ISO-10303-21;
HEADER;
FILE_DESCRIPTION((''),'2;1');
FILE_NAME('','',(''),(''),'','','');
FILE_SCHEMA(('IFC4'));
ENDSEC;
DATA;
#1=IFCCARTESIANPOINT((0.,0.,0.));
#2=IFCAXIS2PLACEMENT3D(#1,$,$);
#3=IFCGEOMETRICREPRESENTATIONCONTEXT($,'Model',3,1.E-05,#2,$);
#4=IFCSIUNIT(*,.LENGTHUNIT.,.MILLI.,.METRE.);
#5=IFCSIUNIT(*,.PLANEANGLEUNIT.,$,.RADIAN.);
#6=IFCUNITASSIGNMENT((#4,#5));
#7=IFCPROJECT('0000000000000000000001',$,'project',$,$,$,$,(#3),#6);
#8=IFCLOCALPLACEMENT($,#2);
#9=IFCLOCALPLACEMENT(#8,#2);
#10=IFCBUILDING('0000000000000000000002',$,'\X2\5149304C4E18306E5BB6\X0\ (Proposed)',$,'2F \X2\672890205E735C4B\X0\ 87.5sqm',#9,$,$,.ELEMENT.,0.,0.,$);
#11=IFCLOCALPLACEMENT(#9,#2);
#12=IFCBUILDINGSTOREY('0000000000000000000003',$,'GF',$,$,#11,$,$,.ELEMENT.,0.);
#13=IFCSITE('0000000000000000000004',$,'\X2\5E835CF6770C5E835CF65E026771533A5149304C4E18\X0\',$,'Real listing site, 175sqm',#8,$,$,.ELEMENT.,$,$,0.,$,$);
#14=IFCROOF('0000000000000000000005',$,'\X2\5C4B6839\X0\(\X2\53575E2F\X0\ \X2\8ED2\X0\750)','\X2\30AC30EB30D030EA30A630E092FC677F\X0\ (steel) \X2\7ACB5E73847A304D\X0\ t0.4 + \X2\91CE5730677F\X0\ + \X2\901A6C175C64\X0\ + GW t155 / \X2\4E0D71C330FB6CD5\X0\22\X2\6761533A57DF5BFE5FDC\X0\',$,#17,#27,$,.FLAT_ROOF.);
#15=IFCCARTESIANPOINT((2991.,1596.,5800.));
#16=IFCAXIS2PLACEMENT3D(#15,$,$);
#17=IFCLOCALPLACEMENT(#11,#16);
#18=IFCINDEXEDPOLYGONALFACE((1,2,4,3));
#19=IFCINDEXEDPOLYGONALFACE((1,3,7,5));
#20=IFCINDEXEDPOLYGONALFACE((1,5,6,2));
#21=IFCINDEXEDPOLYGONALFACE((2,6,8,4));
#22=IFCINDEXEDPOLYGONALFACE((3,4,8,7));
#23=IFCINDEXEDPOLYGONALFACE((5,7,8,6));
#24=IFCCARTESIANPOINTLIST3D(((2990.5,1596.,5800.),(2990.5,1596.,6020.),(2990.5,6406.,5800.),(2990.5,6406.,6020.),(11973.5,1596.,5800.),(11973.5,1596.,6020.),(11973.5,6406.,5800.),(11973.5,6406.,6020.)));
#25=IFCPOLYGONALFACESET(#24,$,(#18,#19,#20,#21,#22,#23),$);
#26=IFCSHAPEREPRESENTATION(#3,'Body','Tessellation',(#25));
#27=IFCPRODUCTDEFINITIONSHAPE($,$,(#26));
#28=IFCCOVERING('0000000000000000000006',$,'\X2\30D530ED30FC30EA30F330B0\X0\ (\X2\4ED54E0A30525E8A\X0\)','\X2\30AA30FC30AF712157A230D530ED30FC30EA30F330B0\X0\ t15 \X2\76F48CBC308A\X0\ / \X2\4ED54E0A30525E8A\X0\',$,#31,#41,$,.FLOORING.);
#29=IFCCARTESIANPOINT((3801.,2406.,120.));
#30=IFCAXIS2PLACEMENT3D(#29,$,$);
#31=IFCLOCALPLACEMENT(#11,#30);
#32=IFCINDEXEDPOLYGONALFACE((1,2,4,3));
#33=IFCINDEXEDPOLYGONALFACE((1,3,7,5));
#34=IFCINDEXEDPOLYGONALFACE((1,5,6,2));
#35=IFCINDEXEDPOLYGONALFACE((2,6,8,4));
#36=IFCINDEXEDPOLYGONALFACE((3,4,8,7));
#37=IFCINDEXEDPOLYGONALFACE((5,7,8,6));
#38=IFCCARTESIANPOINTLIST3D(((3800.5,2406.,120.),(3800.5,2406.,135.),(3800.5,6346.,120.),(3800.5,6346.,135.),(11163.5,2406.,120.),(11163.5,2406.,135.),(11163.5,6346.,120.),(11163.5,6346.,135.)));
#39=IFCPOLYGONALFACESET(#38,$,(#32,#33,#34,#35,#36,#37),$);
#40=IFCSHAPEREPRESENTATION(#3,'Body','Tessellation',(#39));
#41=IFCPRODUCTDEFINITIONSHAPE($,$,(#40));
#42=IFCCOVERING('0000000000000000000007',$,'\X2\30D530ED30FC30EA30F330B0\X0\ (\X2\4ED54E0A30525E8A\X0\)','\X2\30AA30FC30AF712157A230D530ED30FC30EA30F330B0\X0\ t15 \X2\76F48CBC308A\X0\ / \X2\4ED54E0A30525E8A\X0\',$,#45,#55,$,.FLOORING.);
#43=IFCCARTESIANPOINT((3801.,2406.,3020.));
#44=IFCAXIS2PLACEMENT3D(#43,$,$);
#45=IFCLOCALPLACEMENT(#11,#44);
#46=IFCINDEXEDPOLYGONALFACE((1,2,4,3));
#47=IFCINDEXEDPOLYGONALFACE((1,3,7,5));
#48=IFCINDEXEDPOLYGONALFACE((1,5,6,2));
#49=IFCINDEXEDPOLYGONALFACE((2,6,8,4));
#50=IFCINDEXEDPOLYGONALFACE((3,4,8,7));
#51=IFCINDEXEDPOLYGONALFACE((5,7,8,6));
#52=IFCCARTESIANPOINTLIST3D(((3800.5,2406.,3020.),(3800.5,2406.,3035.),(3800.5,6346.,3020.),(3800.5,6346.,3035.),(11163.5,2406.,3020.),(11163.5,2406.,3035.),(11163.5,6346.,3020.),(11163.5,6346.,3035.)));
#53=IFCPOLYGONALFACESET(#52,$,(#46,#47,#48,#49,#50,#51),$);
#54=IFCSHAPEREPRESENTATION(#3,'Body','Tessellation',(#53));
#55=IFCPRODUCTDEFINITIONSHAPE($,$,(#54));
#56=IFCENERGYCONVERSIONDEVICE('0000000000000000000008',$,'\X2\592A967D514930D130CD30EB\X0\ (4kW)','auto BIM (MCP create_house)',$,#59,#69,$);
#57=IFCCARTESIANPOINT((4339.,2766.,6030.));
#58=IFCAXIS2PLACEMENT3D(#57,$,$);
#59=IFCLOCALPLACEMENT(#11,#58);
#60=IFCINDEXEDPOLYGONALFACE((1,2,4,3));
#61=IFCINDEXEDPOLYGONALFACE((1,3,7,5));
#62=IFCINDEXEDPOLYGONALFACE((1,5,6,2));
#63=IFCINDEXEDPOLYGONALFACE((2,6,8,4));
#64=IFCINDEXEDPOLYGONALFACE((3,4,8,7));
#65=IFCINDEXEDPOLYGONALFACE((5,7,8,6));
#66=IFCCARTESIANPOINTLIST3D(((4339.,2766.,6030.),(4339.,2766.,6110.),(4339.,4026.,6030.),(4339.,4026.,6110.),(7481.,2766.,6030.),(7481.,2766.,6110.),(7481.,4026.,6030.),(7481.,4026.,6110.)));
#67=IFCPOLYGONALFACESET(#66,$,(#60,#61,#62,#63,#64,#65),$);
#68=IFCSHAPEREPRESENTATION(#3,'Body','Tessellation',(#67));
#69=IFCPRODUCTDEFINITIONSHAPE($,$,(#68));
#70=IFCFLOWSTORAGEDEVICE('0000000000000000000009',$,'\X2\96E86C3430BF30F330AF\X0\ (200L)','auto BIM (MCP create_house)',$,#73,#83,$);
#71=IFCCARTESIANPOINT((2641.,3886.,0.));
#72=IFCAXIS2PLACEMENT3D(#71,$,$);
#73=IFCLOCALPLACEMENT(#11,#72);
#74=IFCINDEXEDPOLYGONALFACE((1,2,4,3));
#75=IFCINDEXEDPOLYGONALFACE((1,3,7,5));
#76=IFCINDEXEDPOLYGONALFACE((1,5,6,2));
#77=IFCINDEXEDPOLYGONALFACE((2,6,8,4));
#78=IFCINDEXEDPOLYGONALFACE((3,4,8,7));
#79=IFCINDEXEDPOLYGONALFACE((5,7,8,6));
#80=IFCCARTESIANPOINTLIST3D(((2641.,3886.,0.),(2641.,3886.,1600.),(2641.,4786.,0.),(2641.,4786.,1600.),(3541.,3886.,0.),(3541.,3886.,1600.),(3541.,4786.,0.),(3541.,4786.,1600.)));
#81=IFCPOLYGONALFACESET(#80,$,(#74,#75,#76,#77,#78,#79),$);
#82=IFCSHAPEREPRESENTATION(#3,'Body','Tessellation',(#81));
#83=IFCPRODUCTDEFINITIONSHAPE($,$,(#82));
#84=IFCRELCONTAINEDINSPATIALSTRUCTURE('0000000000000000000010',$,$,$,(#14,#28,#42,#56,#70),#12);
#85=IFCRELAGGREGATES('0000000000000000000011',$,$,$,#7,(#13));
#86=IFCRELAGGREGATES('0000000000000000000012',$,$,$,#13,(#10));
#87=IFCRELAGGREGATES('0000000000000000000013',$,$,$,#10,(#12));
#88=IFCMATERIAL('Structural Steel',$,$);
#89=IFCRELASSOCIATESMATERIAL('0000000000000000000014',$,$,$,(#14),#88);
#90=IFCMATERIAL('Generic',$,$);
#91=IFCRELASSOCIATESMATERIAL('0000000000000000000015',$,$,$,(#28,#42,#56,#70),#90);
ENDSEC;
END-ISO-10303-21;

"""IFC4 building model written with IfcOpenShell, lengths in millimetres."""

from ifc_helpers import new_model, si_unit, frame, frame_2d, origin, place, context, project, spatial, rectangle, extrude, material, element, save


model = new_model("IFC4")

# Units and contexts
model_context = context("Model", 3, precision=1e-05, world=origin())
ifc_project = project(units=[si_unit("LENGTHUNIT", "METRE", prefix="MILLI"), si_unit("PLANEANGLEUNIT", "RADIAN")], contexts=[model_context])

# Site, building, storey
site_placement = place(None, origin())
site = spatial("IfcSite", under=ifc_project, at=site_placement, Name="広島県広島市東区光が丘", ObjectType="Real listing site, 175sqm", CompositionType="ELEMENT", RefElevation=0.0)
building_placement = place(site_placement, origin())
building = spatial("IfcBuilding", under=site, at=building_placement, Name="光が丘の家 (Proposed)", ObjectType="2F 木造平屋 87.5sqm", CompositionType="ELEMENT", ElevationOfRefHeight=0.0, ElevationOfTerrain=0.0)
storey_placement = place(building_placement, origin())
storey = spatial("IfcBuildingStorey", under=building, at=storey_placement, Name="GF", CompositionType="ELEMENT", Elevation=0.0)

# Roof
ifc_material_1 = material(Name="Structural Steel")
for number, where, name in (
    (1, (2991.0, 1596.0, 5800.0), "屋根(南帯 軒750)"),
):
    element("IfcRoof", number, at=place(storey_placement, frame(where)), inside=storey, material=ifc_material_1, Name=name, Description="ガルバリウム鋼板 (steel) 立平葺き t0.4 + 野地板 + 通気層 + GW t155 / 不燃・法22条区域対応", PredefinedType="FLAT_ROOF", context=model_context, shape_type="SweptSolid", body=[
        extrude(rectangle(XDim=8983.0, YDim=4810.0, at=frame_2d((4491.0, 2405.0))), frame((2991.0, 1596.0, 5800.0)), (0.0, 0.0, 1.0), 220.0),
    ])

# Coverings
ifc_material_2 = material(Name="Generic")
covering_1_placement = place(storey_placement, frame((3801.0, 2406.0, 120.0)))
element("IfcCovering", 2, at=covering_1_placement, inside=storey, material=ifc_material_2, Name="フローリング (仕上げ床)", Description="オーク無垢フローリング t15 直貼り / 仕上げ床", PredefinedType="FLOORING", context=model_context, shape_type="SweptSolid", body=[
    extrude(rectangle(XDim=7363.0, YDim=3940.0, at=frame_2d((3681.0, 1970.0))), frame((3801.0, 2406.0, 120.0)), (0.0, 0.0, 1.0), 15.0),
])
covering_2_placement = place(storey_placement, frame((3801.0, 2406.0, 3020.0)))
element("IfcCovering", 3, at=covering_2_placement, inside=storey, material=ifc_material_2, Name="フローリング (仕上げ床)", Description="オーク無垢フローリング t15 直貼り / 仕上げ床", PredefinedType="FLOORING", context=model_context, shape_type="SweptSolid", body=[
    extrude(rectangle(XDim=7363.0, YDim=3940.0, at=frame_2d((3681.0, 1970.0))), frame((3801.0, 2406.0, 3020.0)), (0.0, 0.0, 1.0), 15.0),
])

# Energy conversion device
energy_conversion_device_placement = place(storey_placement, frame((4339.0, 2766.0, 6030.0)))
element("IfcEnergyConversionDevice", 4, at=energy_conversion_device_placement, inside=storey, material=ifc_material_2, Name="太陽光パネル (4kW)", Description="auto BIM (MCP create_house)", context=model_context, shape_type="SweptSolid", body=[
    extrude(rectangle(XDim=3142.0, YDim=1260.0, at=frame_2d((1571.0, 630.0))), frame((4339.0, 2766.0, 6030.0)), (0.0, 0.0, 1.0), 80.0),
])

# Flow storage device
flow_storage_device_placement = place(storey_placement, frame((2641.0, 3886.0, 0.0)))
element("IfcFlowStorageDevice", 5, at=flow_storage_device_placement, inside=storey, material=ifc_material_2, Name="雨水タンク (200L)", Description="auto BIM (MCP create_house)", context=model_context, shape_type="SweptSolid", body=[
    extrude(rectangle(XDim=900.0, YDim=900.0, at=frame_2d((450.0, 450.0))), frame((2641.0, 3886.0, 0.0)), (0.0, 0.0, 1.0), 1600.0),
])

save(model, "model.ifc")
